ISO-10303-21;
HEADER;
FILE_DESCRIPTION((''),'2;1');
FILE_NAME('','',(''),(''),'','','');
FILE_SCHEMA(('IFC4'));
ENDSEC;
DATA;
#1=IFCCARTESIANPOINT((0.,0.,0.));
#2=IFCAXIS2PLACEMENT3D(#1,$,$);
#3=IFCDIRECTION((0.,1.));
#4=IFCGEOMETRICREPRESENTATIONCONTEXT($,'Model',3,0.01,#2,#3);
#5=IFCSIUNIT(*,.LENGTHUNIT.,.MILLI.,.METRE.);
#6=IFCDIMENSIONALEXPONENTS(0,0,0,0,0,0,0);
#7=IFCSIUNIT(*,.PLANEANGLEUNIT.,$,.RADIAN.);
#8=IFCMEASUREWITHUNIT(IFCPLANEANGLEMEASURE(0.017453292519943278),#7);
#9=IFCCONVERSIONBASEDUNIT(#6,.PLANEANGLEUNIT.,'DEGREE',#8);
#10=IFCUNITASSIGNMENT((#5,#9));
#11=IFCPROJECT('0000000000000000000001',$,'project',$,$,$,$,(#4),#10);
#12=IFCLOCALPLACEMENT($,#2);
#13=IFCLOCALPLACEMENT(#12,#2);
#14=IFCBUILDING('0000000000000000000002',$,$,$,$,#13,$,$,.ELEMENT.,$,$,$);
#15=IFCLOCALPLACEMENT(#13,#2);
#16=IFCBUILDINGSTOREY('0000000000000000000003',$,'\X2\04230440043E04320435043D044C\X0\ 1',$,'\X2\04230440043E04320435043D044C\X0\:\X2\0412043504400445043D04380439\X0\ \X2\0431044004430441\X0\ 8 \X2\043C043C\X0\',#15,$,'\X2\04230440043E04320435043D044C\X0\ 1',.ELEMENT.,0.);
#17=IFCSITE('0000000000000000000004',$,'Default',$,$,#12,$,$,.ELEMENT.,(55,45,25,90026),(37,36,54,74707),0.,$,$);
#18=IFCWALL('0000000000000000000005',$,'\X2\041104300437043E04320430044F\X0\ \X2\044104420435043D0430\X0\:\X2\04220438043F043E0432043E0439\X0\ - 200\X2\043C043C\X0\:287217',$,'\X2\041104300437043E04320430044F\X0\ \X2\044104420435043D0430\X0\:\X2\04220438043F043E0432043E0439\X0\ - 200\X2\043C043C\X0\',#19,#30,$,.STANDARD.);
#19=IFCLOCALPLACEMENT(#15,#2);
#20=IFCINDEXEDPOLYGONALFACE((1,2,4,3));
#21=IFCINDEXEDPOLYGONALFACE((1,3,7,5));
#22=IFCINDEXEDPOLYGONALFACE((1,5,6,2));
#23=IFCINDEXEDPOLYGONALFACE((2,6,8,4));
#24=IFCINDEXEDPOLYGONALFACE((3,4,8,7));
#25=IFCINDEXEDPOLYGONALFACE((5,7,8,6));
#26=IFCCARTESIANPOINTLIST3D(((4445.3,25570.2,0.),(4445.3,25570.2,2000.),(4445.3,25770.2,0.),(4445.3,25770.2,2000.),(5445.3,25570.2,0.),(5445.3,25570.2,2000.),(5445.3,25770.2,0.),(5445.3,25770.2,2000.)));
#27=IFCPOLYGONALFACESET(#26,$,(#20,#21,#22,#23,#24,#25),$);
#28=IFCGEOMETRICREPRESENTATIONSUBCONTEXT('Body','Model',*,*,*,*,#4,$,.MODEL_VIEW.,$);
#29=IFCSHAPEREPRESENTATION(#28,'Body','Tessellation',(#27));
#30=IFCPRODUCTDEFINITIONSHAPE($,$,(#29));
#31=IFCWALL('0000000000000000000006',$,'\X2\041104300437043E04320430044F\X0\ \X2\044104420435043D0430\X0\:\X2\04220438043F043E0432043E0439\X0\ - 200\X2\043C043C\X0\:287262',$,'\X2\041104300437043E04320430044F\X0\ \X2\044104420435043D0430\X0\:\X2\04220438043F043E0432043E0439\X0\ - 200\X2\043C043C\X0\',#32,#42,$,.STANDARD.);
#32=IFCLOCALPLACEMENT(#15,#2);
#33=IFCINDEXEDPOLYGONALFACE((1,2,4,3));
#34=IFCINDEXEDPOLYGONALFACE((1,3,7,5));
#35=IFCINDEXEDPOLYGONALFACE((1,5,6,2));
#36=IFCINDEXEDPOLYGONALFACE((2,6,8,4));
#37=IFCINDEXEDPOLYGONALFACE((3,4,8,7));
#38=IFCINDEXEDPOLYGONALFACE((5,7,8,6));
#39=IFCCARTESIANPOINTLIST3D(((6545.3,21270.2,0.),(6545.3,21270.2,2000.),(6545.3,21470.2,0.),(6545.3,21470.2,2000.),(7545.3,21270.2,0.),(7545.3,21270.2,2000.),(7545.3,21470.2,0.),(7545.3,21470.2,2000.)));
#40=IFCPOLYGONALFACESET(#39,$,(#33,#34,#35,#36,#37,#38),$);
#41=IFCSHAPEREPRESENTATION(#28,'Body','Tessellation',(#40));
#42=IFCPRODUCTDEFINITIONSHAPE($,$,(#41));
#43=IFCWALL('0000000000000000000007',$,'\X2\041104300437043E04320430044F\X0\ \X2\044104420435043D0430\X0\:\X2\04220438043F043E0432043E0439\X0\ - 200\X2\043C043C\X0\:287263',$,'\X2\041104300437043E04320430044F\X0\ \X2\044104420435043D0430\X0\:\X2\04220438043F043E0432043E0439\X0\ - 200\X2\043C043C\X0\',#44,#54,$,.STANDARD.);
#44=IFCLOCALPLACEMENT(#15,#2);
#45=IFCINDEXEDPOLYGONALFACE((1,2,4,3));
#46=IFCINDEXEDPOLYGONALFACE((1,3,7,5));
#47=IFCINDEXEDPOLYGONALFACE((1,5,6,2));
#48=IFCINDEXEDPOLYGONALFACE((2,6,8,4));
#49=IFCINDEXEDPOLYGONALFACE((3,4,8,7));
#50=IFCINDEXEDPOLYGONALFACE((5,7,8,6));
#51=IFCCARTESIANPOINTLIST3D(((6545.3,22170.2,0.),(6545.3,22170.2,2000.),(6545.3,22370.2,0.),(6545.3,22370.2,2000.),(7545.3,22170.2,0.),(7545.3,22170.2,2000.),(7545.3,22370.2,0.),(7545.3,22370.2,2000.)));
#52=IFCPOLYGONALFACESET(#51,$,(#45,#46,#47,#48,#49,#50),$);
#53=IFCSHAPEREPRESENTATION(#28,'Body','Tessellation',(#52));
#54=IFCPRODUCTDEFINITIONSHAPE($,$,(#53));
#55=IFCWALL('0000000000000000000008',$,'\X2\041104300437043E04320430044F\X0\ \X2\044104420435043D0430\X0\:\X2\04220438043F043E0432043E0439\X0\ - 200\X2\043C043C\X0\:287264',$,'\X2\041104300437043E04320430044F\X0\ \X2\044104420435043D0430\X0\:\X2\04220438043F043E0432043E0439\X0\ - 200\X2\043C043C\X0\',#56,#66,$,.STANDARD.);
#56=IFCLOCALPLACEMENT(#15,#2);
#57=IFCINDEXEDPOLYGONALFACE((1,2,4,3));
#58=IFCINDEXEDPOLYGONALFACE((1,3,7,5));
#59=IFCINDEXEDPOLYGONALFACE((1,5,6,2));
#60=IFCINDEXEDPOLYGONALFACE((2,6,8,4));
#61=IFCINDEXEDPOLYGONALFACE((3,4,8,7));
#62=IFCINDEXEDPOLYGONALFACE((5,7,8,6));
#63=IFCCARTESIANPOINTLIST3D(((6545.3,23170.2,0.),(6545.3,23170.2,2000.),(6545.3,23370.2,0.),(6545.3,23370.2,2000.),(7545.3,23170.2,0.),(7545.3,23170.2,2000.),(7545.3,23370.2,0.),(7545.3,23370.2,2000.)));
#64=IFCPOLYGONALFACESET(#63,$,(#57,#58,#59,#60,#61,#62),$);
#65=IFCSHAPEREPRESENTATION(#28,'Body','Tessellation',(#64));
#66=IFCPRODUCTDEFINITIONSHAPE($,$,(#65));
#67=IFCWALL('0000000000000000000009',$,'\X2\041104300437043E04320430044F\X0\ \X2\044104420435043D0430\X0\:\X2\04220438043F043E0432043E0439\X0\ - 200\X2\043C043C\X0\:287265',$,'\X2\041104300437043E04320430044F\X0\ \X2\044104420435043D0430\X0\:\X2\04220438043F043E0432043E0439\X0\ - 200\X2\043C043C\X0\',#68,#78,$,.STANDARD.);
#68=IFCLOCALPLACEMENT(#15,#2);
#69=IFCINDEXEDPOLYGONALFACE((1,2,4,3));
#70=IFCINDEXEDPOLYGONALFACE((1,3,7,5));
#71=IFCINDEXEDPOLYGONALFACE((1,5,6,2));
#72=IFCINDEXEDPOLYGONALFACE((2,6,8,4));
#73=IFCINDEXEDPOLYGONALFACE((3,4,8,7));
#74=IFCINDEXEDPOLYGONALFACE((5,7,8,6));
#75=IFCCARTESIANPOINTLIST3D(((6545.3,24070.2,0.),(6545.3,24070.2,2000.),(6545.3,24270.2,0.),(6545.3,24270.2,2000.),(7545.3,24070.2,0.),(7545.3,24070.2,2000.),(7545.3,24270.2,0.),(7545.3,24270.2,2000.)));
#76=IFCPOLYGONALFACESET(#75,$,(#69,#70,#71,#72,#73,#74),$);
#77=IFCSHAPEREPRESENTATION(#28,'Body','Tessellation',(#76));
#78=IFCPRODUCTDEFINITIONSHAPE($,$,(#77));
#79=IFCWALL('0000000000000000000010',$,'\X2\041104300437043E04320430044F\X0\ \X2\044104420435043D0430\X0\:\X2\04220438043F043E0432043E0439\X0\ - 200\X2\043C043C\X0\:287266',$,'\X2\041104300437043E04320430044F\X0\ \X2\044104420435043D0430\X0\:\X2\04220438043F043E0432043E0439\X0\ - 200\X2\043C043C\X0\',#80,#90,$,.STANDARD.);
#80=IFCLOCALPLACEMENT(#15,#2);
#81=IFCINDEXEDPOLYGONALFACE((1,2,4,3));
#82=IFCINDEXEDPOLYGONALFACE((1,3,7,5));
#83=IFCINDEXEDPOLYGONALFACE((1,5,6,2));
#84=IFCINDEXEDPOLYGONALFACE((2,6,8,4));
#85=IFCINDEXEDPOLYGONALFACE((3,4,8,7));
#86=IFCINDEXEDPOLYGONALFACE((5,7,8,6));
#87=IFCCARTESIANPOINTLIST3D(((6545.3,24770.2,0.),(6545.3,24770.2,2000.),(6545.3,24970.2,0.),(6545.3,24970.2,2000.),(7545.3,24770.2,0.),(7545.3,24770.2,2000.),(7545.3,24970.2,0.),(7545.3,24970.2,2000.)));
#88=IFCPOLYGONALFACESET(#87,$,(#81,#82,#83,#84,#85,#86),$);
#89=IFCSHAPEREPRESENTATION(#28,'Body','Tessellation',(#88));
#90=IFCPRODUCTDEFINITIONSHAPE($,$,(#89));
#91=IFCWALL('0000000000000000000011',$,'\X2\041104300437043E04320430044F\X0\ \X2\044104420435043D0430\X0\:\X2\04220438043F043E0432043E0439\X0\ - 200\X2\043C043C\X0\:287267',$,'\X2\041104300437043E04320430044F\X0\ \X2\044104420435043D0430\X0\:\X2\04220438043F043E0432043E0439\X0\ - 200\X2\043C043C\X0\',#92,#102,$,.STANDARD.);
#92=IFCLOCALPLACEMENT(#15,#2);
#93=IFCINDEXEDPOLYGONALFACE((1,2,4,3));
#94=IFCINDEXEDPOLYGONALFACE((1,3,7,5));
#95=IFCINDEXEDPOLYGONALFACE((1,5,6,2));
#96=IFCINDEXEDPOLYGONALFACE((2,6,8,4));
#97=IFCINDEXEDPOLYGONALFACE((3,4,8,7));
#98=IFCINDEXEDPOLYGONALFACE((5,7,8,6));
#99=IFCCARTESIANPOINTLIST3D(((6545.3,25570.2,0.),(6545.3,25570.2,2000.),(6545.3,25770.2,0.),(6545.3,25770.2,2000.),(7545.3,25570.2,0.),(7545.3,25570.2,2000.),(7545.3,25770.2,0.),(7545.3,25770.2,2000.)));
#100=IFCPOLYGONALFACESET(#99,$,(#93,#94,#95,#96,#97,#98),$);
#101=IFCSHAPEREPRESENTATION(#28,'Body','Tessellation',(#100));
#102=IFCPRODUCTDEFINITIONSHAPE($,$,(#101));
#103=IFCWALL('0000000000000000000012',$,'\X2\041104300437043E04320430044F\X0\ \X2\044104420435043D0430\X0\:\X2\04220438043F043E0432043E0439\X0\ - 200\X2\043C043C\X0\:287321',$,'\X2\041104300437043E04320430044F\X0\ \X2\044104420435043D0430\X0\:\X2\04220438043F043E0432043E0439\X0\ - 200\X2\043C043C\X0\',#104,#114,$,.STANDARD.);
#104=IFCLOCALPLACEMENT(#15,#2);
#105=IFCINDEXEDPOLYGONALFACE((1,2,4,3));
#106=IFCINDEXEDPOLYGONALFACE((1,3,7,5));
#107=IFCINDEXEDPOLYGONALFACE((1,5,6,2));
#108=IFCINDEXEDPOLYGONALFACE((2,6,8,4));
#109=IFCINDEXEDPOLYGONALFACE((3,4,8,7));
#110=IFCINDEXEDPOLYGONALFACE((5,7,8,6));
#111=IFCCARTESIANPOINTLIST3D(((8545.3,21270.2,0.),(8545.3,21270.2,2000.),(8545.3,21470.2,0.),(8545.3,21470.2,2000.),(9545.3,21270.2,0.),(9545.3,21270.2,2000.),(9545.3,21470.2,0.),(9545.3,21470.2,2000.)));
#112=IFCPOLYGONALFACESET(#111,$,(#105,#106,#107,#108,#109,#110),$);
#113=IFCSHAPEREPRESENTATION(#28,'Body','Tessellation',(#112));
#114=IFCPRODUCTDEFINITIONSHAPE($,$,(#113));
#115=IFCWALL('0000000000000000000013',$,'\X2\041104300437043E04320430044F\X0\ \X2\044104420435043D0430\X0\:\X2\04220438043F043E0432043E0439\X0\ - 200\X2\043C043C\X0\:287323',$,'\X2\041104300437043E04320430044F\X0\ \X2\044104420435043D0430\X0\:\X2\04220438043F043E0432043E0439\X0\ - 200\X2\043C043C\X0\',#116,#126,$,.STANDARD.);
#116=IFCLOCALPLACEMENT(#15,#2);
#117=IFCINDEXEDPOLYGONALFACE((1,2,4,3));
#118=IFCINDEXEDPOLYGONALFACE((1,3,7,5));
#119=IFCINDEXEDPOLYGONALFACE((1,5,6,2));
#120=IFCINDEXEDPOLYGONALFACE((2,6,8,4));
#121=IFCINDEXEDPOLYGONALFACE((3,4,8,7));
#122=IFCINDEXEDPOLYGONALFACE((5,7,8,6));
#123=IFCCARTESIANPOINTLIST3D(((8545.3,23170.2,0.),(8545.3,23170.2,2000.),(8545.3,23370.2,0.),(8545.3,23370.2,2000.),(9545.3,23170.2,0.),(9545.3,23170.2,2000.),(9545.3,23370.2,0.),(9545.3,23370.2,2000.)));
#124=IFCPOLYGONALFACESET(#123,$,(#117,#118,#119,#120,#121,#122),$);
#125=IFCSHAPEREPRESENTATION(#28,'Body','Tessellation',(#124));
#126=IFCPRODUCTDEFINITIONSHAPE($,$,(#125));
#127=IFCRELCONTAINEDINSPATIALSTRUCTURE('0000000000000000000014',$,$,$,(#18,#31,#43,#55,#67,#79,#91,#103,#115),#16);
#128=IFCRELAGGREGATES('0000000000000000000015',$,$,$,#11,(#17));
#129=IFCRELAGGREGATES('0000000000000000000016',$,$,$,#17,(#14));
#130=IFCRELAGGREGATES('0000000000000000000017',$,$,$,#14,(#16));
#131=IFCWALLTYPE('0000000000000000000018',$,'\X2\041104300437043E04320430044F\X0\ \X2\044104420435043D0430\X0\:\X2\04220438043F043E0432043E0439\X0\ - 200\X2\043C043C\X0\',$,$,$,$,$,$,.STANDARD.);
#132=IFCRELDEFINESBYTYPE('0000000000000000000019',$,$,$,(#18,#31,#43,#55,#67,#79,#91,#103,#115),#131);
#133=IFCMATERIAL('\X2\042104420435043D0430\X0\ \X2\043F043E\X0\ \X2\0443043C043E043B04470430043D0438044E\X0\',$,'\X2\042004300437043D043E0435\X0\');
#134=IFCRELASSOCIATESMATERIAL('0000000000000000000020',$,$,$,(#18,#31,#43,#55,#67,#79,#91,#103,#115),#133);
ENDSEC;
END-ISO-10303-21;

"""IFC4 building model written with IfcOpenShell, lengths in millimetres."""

from ifc_helpers import new_model, entity, si_unit, converted_unit, direction, frame, origin, place, context, subcontext, project, spatial, indexed_curve, outline, extrude, material, type_object, element, save


model = new_model("IFC4")

# Units and contexts
model_context = context("Model", 3, precision=0.01, world=origin(), true_north=direction((0.0, 1.0)))
body_context = subcontext(model_context, "Body", "Model", "MODEL_VIEW")
ifc_project = project(units=[si_unit("LENGTHUNIT", "METRE", prefix="MILLI"), converted_unit("PLANEANGLEUNIT", "DEGREE", entity("IfcPlaneAngleMeasure", 0.017453292519943278), si_unit("PLANEANGLEUNIT", "RADIAN"), dimensions=[0, 0, 0, 0, 0, 0, 0])], contexts=[model_context])

# Site, building, storey
site_placement = place(None, origin())
site = spatial("IfcSite", under=ifc_project, at=site_placement, Name="Default", CompositionType="ELEMENT", RefLatitude=(55, 45, 25, 90026), RefLongitude=(37, 36, 54, 74707), RefElevation=0.0)
building_placement = place(site_placement, origin())
building = spatial("IfcBuilding", under=site, at=building_placement, CompositionType="ELEMENT")
storey_placement = place(building_placement, origin())
storey = spatial("IfcBuildingStorey", under=building, at=storey_placement, Name="Уровень 1", ObjectType="Уровень:Верхний брус 8 мм", LongName="Уровень 1", CompositionType="ELEMENT", Elevation=0.0)

# Walls
ifc_material = material(Name="Стена по умолчанию", Category="Разное")
wall_type = type_object("IfcWallType", Name="Базовая стена:Типовой - 200мм", PredefinedType="STANDARD")
wall_1_placement = place(storey_placement, frame((4445.3, 25670.2, 0.0)))
element("IfcWall", 1, at=wall_1_placement, inside=storey, type_object=wall_type, material=ifc_material, Name="Базовая стена:Типовой - 200мм:287217", ObjectType="Базовая стена:Типовой - 200мм", PredefinedType="STANDARD", context=body_context, shape_type="SweptSolid", body=[
    extrude(outline(indexed_curve([(1000.0, 100.0), (0.0, 100.0), (0.0, -100.0), (1000.0, -100.0), (1000.0, 100.0)], self_intersect=False)), origin(), (0.0, 0.0, 1.0), 2000.0),
])
for number, where, name in (
    (2, (6545.3, 21370.2, 0.0), "Базовая стена:Типовой - 200мм:287262"),
    (3, (6545.3, 22270.2, 0.0), "Базовая стена:Типовой - 200мм:287263"),
):
    element("IfcWall", number, at=place(storey_placement, frame(where)), inside=storey, type_object=wall_type, material=ifc_material, Name=name, ObjectType="Базовая стена:Типовой - 200мм", PredefinedType="STANDARD", context=body_context, shape_type="SweptSolid", body=[
        extrude(outline(indexed_curve([(1000.0, 100.0), (0.0, 100.0), (0.0, -100.0), (1000.0, -100.0), (1000.0, 100.0)], self_intersect=False)), origin(), (0.0, 0.0, 1.0), 2000.0),
    ])
for number, where, name in (
    (4, (6545.3, 23270.2, 0.0), "Базовая стена:Типовой - 200мм:287264"),
    (5, (6545.3, 24170.2, 0.0), "Базовая стена:Типовой - 200мм:287265"),
    (6, (6545.3, 24870.2, 0.0), "Базовая стена:Типовой - 200мм:287266"),
):
    element("IfcWall", number, at=place(storey_placement, frame(where)), inside=storey, type_object=wall_type, material=ifc_material, Name=name, ObjectType="Базовая стена:Типовой - 200мм", PredefinedType="STANDARD", context=body_context, shape_type="SweptSolid", body=[
        extrude(outline(indexed_curve([(1000.0, 100.0), (0.0, 100.0), (0.0, -100.0), (1000.0, -100.0), (1000.0, 100.0)], self_intersect=False)), origin(), (0.0, 0.0, 1.0), 2000.0),
    ])
for number, where, name in (
    (7, (6545.3, 25670.2, 0.0), "Базовая стена:Типовой - 200мм:287267"),
    (8, (8545.3, 21370.2, 0.0), "Базовая стена:Типовой - 200мм:287321"),
):
    element("IfcWall", number, at=place(storey_placement, frame(where)), inside=storey, type_object=wall_type, material=ifc_material, Name=name, ObjectType="Базовая стена:Типовой - 200мм", PredefinedType="STANDARD", context=body_context, shape_type="SweptSolid", body=[
        extrude(outline(indexed_curve([(1000.0, 100.0), (0.0, 100.0), (0.0, -100.0), (1000.0, -100.0), (1000.0, 100.0)], self_intersect=False)), origin(), (0.0, 0.0, 1.0), 2000.0),
    ])
wall_2_placement = place(storey_placement, frame((8545.3, 23270.2, 0.0)))
element("IfcWall", 9, at=wall_2_placement, inside=storey, type_object=wall_type, material=ifc_material, Name="Базовая стена:Типовой - 200мм:287323", ObjectType="Базовая стена:Типовой - 200мм", PredefinedType="STANDARD", context=body_context, shape_type="SweptSolid", body=[
    extrude(outline(indexed_curve([(1000.0, 100.0), (0.0, 100.0), (0.0, -100.0), (1000.0, -100.0), (1000.0, 100.0)], self_intersect=False)), origin(), (0.0, 0.0, 1.0), 2000.0),
])

save(model, "model.ifc")
